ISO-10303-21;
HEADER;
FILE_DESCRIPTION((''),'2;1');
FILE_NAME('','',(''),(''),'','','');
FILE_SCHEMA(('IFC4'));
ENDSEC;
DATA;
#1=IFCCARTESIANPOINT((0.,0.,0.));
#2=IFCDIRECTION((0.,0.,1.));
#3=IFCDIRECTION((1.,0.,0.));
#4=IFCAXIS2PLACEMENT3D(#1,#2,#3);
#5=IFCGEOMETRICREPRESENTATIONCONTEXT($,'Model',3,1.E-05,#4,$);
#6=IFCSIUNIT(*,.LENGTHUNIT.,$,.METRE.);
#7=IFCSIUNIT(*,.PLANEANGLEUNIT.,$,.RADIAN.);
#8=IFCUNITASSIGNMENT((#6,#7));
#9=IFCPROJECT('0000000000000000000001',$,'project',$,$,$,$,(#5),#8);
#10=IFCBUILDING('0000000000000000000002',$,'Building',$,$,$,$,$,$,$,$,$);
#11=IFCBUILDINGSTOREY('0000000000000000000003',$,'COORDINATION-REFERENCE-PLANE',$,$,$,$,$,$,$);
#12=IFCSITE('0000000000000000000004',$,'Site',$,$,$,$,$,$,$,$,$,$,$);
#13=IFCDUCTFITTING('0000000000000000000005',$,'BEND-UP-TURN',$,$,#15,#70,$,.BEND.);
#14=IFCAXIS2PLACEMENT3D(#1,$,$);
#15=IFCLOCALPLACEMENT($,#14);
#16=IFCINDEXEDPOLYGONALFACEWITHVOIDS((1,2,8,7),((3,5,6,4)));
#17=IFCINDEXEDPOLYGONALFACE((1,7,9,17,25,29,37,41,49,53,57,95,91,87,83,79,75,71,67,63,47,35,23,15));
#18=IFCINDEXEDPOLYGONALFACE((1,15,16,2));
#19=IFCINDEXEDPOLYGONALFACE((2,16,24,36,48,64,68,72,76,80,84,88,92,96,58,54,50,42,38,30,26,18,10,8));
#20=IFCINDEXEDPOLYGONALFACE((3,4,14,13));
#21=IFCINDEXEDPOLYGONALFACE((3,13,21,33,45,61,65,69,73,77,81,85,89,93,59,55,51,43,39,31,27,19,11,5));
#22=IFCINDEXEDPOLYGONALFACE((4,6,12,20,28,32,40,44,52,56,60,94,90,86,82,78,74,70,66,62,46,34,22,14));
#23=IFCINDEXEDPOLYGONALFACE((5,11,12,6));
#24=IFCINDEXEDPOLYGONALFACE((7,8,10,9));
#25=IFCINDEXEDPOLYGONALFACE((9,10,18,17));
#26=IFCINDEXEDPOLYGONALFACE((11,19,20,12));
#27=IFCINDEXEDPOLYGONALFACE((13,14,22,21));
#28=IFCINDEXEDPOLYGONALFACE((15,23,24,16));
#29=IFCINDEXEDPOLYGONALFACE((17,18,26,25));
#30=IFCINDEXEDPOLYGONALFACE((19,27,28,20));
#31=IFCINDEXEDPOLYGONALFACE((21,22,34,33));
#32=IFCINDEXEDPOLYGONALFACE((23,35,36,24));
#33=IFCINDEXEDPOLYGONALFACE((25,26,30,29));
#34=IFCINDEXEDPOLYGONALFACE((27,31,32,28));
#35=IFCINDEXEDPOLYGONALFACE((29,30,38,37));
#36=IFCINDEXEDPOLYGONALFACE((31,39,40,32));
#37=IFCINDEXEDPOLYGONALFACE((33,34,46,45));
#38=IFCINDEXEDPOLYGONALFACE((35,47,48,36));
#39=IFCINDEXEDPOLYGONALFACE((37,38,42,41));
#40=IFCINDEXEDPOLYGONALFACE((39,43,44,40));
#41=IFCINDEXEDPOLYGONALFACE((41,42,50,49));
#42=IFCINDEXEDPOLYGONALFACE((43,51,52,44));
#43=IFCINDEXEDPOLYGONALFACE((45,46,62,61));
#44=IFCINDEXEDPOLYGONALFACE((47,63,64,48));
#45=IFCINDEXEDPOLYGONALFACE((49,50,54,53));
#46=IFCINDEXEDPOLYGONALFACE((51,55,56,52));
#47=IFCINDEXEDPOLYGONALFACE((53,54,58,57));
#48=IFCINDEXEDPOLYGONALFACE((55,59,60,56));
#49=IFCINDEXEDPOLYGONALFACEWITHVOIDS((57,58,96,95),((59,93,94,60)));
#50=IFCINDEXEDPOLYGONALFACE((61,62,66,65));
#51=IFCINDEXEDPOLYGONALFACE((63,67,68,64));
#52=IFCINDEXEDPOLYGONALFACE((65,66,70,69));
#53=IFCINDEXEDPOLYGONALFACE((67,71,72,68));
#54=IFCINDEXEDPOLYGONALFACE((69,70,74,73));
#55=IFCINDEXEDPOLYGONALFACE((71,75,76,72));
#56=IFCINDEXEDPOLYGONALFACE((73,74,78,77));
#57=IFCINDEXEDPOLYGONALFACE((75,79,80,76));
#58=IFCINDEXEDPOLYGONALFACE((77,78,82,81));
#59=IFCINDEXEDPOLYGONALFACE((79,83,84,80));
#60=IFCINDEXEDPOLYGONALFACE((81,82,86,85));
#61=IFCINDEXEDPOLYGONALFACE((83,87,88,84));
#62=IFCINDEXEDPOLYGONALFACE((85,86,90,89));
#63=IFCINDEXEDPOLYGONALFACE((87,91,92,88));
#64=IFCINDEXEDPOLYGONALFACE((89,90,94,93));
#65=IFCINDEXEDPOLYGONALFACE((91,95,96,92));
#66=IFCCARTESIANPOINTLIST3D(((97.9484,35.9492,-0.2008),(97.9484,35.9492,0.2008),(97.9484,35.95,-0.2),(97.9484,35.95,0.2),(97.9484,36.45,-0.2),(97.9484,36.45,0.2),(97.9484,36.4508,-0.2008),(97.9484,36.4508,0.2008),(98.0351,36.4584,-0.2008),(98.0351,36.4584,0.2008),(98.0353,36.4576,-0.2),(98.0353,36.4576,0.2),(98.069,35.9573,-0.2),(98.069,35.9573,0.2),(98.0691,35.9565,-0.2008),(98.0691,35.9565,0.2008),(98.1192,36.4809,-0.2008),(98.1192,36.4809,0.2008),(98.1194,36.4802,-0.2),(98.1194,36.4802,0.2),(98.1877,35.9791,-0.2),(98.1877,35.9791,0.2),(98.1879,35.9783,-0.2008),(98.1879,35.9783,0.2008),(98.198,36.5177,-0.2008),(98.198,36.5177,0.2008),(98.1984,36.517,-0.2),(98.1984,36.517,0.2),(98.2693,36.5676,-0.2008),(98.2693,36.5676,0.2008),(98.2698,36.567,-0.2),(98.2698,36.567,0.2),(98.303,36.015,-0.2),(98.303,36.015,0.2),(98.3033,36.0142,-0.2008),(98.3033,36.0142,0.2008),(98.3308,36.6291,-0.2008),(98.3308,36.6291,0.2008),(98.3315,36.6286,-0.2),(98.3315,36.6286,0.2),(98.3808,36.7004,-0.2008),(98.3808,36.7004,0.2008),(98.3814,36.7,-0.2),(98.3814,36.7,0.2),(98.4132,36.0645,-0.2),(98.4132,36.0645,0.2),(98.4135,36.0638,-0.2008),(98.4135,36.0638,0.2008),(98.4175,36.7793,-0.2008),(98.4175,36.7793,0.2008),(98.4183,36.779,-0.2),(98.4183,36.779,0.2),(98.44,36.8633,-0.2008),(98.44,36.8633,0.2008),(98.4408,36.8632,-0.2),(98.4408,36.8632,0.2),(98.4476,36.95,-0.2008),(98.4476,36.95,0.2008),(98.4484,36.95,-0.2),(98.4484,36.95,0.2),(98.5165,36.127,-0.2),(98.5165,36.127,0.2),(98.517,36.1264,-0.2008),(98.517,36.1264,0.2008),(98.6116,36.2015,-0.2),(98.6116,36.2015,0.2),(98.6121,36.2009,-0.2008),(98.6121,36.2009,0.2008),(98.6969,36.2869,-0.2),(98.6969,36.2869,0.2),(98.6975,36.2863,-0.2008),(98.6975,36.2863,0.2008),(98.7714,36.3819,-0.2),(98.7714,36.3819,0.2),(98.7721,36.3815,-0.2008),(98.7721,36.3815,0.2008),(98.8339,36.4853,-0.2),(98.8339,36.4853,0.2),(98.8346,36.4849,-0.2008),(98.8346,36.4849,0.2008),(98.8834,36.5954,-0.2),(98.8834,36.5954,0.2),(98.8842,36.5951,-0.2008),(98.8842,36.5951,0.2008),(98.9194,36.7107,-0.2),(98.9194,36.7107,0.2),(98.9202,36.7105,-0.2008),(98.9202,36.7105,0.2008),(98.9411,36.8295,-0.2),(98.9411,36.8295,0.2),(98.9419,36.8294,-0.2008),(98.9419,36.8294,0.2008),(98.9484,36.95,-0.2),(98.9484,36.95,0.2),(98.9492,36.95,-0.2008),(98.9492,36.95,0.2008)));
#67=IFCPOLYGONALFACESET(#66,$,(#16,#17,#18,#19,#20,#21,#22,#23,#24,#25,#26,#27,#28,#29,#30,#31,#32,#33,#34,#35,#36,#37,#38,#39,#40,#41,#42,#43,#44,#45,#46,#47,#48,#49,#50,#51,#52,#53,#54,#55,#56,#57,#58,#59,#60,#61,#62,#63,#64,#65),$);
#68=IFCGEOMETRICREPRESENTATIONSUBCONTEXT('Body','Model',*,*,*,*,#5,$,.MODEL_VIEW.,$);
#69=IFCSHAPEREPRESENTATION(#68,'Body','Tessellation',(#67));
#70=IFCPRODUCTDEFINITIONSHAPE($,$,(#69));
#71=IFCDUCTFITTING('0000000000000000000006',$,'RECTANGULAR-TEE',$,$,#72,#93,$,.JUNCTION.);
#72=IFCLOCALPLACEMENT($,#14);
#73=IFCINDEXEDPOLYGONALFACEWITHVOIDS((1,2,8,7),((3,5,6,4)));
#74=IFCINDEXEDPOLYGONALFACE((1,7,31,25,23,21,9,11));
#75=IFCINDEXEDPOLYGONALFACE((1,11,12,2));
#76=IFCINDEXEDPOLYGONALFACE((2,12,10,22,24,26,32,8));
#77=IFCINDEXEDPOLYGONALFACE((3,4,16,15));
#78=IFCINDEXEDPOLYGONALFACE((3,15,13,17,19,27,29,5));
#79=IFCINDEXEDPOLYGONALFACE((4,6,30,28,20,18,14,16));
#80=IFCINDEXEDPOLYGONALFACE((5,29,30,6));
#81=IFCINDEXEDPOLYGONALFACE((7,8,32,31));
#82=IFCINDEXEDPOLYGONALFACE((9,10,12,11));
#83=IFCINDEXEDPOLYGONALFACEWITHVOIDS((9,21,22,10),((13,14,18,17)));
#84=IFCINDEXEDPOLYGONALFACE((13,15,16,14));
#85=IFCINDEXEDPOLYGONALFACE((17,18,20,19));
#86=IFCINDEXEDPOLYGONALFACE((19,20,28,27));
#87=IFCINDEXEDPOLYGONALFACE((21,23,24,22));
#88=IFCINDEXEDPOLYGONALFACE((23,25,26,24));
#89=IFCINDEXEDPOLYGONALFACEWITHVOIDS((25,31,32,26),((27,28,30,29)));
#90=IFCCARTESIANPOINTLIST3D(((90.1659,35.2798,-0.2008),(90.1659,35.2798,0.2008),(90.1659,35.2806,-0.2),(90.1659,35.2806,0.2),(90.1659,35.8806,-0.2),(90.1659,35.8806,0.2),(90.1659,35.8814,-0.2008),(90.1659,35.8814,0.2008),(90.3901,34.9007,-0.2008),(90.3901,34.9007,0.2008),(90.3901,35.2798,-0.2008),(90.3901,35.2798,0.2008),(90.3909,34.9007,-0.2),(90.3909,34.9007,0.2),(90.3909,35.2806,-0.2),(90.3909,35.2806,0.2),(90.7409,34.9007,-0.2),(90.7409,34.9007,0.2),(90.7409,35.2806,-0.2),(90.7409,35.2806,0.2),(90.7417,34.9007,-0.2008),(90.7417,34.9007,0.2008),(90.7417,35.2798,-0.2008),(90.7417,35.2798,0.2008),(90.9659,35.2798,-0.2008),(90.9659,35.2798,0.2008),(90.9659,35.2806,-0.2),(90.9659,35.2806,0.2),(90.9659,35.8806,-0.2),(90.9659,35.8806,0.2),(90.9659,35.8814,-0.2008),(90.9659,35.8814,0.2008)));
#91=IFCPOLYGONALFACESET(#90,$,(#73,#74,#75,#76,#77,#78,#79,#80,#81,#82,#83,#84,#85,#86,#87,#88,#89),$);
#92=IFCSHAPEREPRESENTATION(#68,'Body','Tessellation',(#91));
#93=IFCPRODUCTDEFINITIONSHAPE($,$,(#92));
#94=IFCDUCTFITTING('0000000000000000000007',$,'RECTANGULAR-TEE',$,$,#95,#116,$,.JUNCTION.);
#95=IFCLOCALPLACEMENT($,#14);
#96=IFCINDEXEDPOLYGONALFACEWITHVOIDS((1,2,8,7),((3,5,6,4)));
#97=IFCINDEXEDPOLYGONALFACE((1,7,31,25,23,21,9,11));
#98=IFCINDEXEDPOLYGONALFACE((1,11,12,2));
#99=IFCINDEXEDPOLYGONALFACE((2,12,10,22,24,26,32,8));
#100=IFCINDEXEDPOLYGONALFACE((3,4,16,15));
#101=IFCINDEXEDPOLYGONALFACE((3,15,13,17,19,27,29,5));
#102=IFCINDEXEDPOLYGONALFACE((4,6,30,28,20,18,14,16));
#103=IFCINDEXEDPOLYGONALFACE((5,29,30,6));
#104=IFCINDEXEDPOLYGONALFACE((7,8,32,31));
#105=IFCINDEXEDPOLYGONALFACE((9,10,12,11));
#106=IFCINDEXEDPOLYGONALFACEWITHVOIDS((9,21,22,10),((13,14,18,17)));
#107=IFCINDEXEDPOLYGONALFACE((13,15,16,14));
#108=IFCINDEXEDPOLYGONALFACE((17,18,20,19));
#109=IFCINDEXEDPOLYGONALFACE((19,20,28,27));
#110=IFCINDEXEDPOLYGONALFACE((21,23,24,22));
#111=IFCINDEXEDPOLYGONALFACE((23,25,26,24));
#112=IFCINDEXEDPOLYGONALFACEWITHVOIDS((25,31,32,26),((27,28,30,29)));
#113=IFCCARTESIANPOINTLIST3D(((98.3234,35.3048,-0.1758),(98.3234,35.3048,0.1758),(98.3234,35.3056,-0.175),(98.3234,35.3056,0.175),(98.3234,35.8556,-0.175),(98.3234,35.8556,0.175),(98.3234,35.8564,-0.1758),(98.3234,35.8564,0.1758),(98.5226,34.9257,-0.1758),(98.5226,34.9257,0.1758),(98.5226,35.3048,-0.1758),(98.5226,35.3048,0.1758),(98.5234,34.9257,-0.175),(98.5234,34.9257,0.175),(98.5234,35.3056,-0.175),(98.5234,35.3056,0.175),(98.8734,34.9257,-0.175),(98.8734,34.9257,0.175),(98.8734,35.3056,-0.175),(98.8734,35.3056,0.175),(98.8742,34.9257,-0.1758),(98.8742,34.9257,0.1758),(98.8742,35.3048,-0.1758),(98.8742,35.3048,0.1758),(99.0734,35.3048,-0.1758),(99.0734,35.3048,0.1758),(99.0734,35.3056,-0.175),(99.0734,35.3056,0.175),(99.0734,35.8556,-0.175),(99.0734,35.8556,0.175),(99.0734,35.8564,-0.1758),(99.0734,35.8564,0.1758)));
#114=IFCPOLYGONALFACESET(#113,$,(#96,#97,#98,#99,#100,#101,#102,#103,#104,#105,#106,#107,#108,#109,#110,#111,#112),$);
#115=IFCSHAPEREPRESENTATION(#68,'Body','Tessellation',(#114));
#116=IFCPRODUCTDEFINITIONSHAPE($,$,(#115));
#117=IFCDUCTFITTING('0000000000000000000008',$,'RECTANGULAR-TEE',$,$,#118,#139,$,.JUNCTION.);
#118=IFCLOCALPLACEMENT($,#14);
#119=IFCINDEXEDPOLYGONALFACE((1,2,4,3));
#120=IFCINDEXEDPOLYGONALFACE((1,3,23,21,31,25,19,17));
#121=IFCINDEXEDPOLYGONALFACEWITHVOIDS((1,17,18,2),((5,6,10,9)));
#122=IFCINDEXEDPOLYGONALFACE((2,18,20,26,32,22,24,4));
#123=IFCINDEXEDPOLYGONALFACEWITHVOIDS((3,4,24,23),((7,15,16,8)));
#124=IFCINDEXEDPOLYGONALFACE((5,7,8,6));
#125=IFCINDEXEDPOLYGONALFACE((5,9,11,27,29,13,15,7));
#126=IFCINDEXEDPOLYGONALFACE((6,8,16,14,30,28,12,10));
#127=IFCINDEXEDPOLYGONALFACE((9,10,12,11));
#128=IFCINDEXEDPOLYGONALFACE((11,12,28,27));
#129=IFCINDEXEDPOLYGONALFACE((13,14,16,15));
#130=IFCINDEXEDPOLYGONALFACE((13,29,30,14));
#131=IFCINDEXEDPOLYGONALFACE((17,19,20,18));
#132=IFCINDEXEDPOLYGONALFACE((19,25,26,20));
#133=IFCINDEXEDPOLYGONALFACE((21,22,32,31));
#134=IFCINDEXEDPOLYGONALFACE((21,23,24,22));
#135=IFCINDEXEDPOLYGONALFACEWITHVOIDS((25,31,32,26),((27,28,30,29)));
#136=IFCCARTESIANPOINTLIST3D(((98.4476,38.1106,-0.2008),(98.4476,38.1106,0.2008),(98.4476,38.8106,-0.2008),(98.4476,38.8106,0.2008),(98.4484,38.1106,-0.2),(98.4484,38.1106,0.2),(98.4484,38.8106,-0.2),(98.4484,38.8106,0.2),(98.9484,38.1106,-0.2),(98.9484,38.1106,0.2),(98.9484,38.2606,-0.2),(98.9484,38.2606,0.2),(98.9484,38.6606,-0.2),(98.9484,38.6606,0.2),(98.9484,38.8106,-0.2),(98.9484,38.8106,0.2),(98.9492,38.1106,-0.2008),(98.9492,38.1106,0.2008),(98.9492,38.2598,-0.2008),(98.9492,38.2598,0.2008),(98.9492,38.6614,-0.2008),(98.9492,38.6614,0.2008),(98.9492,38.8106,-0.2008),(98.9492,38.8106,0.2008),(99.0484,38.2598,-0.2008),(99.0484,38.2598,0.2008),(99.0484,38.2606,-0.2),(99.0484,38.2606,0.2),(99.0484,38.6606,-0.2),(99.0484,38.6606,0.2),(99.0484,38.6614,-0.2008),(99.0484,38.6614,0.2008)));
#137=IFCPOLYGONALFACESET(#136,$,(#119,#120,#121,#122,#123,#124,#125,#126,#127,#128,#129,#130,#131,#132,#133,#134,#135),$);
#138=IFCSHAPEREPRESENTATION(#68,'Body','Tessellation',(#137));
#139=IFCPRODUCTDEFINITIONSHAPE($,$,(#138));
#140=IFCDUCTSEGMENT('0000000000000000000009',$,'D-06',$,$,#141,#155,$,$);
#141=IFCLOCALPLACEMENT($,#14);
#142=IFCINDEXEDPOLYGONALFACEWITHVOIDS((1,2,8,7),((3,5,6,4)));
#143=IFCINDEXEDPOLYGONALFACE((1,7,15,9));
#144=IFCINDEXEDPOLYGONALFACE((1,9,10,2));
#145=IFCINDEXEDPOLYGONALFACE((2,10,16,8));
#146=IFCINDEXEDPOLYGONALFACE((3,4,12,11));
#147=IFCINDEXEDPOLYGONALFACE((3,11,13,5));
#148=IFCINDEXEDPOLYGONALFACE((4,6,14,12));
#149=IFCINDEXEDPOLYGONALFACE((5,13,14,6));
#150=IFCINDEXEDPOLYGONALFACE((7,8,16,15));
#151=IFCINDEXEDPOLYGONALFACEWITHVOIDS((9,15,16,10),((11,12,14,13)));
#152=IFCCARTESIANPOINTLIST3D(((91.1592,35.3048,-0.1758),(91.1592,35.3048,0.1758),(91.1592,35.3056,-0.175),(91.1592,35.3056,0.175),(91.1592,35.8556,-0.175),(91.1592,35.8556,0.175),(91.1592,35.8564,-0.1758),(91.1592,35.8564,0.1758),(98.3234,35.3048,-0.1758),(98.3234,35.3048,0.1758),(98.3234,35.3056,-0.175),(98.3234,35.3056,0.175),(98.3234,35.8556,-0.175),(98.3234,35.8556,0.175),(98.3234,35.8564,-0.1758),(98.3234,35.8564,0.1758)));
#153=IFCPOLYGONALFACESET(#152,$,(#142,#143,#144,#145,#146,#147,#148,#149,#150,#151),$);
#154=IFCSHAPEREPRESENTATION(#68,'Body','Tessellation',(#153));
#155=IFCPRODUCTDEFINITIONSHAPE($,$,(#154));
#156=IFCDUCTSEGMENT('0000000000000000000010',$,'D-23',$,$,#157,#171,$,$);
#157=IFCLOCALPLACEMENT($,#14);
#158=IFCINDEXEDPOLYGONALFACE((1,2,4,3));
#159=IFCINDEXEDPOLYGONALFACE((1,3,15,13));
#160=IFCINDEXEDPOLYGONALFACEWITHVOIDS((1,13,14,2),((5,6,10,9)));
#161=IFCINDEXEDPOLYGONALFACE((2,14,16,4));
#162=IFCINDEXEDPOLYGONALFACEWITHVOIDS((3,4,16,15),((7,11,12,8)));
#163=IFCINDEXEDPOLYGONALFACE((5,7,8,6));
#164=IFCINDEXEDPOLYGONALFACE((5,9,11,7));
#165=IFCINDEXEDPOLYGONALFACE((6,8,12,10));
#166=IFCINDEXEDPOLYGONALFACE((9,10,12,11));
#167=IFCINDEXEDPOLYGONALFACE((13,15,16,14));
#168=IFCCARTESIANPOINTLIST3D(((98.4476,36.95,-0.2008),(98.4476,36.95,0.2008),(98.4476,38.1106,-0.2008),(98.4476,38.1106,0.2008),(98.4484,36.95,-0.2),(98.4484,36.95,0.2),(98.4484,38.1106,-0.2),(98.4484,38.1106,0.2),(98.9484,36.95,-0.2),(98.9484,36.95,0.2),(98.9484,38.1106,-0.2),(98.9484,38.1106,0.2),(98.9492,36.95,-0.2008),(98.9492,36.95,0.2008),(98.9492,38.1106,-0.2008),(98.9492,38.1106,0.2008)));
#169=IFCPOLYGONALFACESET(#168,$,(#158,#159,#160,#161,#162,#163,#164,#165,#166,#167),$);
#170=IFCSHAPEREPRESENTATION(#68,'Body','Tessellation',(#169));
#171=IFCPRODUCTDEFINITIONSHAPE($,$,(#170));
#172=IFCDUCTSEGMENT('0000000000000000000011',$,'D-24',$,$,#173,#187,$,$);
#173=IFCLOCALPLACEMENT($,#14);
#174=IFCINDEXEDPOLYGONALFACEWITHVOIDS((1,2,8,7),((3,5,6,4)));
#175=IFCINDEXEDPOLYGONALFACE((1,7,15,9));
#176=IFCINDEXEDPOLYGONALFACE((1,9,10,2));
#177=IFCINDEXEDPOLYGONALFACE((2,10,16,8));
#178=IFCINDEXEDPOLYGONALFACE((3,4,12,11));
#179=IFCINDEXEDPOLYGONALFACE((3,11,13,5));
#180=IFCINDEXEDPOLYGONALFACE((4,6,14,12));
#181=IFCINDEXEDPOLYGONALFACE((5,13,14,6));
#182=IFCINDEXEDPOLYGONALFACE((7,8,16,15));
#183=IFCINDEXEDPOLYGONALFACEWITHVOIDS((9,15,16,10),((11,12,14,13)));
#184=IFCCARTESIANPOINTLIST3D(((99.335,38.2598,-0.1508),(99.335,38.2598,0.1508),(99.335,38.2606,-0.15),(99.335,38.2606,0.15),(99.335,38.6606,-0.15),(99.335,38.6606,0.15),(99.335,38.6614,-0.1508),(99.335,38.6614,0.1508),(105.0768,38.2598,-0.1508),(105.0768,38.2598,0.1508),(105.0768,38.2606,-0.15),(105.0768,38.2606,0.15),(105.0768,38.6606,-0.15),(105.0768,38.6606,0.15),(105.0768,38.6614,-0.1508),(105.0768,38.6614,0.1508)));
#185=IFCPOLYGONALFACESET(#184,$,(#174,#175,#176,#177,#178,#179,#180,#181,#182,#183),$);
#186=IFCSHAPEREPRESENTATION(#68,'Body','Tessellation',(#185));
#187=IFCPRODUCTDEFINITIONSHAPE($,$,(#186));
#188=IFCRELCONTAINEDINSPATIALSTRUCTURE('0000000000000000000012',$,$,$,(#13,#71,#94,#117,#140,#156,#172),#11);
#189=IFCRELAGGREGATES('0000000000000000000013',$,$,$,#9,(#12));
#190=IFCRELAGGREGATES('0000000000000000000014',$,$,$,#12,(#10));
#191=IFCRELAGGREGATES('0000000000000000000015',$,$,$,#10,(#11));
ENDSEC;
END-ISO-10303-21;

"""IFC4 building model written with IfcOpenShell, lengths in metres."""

from ifc_helpers import new_model, entity, si_unit, frame, origin, origin_with_axes, place, context, subcontext, project, spatial, rectangle, hollow_rectangle, extrude, boolean, element, save


model = new_model("IFC4")

# Units and contexts
model_context_1 = context("Model", 3, precision=1e-05, world=origin_with_axes())
body_context_1 = subcontext(model_context_1, "Body", "Model", "MODEL_VIEW")
ifc_project = project(units=[si_unit("LENGTHUNIT", "METRE"), si_unit("PLANEANGLEUNIT", "RADIAN")], contexts=[model_context_1])

# Site, building, storey
site = spatial("IfcSite", under=ifc_project, Name="Site")
building = spatial("IfcBuilding", under=site, Name="Building")
storey = spatial("IfcBuildingStorey", under=building, Name="COORDINATION-REFERENCE-PLANE")

# Duct fittings
duct_fitting_1_placement = place(None, frame((97.9484, 36.95, 0.0), z_axis=(0.0, 0.0, 1.0), x_axis=(0.0, -1.0, 0.0)))
cartesian_point = entity("IfcCartesianPoint", [0.0, 0.0, 0.0])
element("IfcDuctFitting", 1, at=duct_fitting_1_placement, inside=storey, Name="BEND-UP-TURN", PredefinedType="BEND", context=body_context_1, shape_type="SweptSolid", body=[
    entity("IfcRevolvedAreaSolid", entity("IfcRectangleHollowProfileDef", "AREA", None, entity("IfcAxis2Placement2D", entity("IfcCartesianPoint", [0.75, 0.0])), 0.5016, 0.4016, 0.0008), entity("IfcAxis2Placement3D", cartesian_point, entity("IfcDirection", [0.0, -1.0, 0.0]), entity("IfcDirection", [1.0, 0.0, 0.0])), entity("IfcAxis1Placement", cartesian_point, entity("IfcDirection", [0.0, 1.0, 0.0])), 1.570796),
])
duct_fitting_2_placement = place(None, frame((90.5659, 35.5806, 0.0), z_axis=(1.0, 0.0, 0.0), x_axis=(0.0, -1.0, 0.0)))
solid_1 = boolean("UNION", extrude(rectangle(XDim=0.6, YDim=0.4), frame((0.0, 0.0, -0.4), z_axis=(0.0, 0.0, 1.0), x_axis=(1.0, 0.0, 0.0)), (0.0, 0.0, 1.0), 0.8), extrude(rectangle(XDim=0.35, YDim=0.4), frame((0.0, 0.0, 0.0), z_axis=(1.0, 0.0, 0.0), x_axis=(0.0, 0.0, -1.0)), (0.0, 0.0, 1.0), 0.6799))
element("IfcDuctFitting", 2, at=duct_fitting_2_placement, inside=storey, Name="RECTANGULAR-TEE", PredefinedType="JUNCTION", context=body_context_1, shape_type="CSG", body=[
    boolean("DIFFERENCE", boolean("UNION", extrude(rectangle(XDim=0.6016, YDim=0.4016), frame((0.0, 0.0, -0.4), z_axis=(0.0, 0.0, 1.0), x_axis=(1.0, 0.0, 0.0)), (0.0, 0.0, 1.0), 0.8), extrude(rectangle(XDim=0.3516, YDim=0.4016), frame((0.0, 0.0, 0.0), z_axis=(1.0, 0.0, 0.0), x_axis=(0.0, 0.0, -1.0)), (0.0, 0.0, 1.0), 0.6799)), solid_1),
])
duct_fitting_3_placement = place(None, frame((98.6984, 35.5806, 0.0), z_axis=(1.0, 0.0, 0.0), x_axis=(0.0, -1.0, 0.0)))
solid_2 = boolean("UNION", extrude(rectangle(XDim=0.55, YDim=0.35), frame((0.0, 0.0, -0.375), z_axis=(0.0, 0.0, 1.0), x_axis=(1.0, 0.0, 0.0)), (0.0, 0.0, 1.0), 0.75), extrude(rectangle(XDim=0.35, YDim=0.35), frame((0.0, 0.0, 0.0), z_axis=(1.0, 0.0, 0.0), x_axis=(0.0, 0.0, -1.0)), (0.0, 0.0, 1.0), 0.6549))
element("IfcDuctFitting", 3, at=duct_fitting_3_placement, inside=storey, Name="RECTANGULAR-TEE", PredefinedType="JUNCTION", context=body_context_1, shape_type="CSG", body=[
    boolean("DIFFERENCE", boolean("UNION", extrude(rectangle(XDim=0.5516, YDim=0.3516), frame((0.0, 0.0, -0.375), z_axis=(0.0, 0.0, 1.0), x_axis=(1.0, 0.0, 0.0)), (0.0, 0.0, 1.0), 0.75), extrude(rectangle(XDim=0.3516, YDim=0.3516), frame((0.0, 0.0, 0.0), z_axis=(1.0, 0.0, 0.0), x_axis=(0.0, 0.0, -1.0)), (0.0, 0.0, 1.0), 0.6549)), solid_2),
])
duct_fitting_4_placement = place(None, frame((98.6984, 38.4606, 0.0), z_axis=(0.0, 1.0, 0.0), x_axis=(1.0, 0.0, 0.0)))
solid_3 = boolean("UNION", extrude(rectangle(XDim=0.5, YDim=0.4), frame((0.0, 0.0, -0.35), z_axis=(0.0, 0.0, 1.0), x_axis=(1.0, 0.0, 0.0)), (0.0, 0.0, 1.0), 0.7), extrude(rectangle(XDim=0.4, YDim=0.4), frame((0.0, 0.0, 0.0), z_axis=(1.0, 0.0, 0.0), x_axis=(0.0, 0.0, -1.0)), (0.0, 0.0, 1.0), 0.35))
element("IfcDuctFitting", 4, at=duct_fitting_4_placement, inside=storey, Name="RECTANGULAR-TEE", PredefinedType="JUNCTION", context=body_context_1, shape_type="CSG", body=[
    boolean("DIFFERENCE", boolean("UNION", extrude(rectangle(XDim=0.5016, YDim=0.4016), frame((0.0, 0.0, -0.35), z_axis=(0.0, 0.0, 1.0), x_axis=(1.0, 0.0, 0.0)), (0.0, 0.0, 1.0), 0.7), extrude(rectangle(XDim=0.4016, YDim=0.4016), frame((0.0, 0.0, 0.0), z_axis=(1.0, 0.0, 0.0), x_axis=(0.0, 0.0, -1.0)), (0.0, 0.0, 1.0), 0.35)), solid_3),
])

# Duct segments
duct_segment_1_placement = place(None, frame((91.1592, 35.5806, 0.0), z_axis=(1.0, 0.0, 0.0), x_axis=(0.0, 1.0, 0.0)))
element("IfcDuctSegment", 5, at=duct_segment_1_placement, inside=storey, Name="D-06", context=body_context_1, shape_type="SweptSolid", body=[
    extrude(hollow_rectangle(XDim=0.5516, YDim=0.3516, WallThickness=0.0008), origin(), (0.0, 0.0, 1.0), 7.1642),
])
duct_segment_2_placement = place(None, frame((98.6984, 36.95, 0.0), z_axis=(0.0, 1.0, 0.0), x_axis=(1.0, 0.0, 0.0)))
element("IfcDuctSegment", 6, at=duct_segment_2_placement, inside=storey, Name="D-23", context=body_context_1, shape_type="SweptSolid", body=[
    extrude(hollow_rectangle(XDim=0.5016, YDim=0.4016, WallThickness=0.0008), origin(), (0.0, 0.0, 1.0), 1.1606),
])
duct_segment_3_placement = place(None, frame((99.335, 38.4606, 0.0), z_axis=(1.0, 0.0, 0.0), x_axis=(0.0, 1.0, 0.0)))
element("IfcDuctSegment", 7, at=duct_segment_3_placement, inside=storey, Name="D-24", context=body_context_1, shape_type="SweptSolid", body=[
    extrude(hollow_rectangle(XDim=0.4016, YDim=0.3016, WallThickness=0.0008), origin(), (0.0, 0.0, 1.0), 5.7417),
])

save(model, "model.ifc")
